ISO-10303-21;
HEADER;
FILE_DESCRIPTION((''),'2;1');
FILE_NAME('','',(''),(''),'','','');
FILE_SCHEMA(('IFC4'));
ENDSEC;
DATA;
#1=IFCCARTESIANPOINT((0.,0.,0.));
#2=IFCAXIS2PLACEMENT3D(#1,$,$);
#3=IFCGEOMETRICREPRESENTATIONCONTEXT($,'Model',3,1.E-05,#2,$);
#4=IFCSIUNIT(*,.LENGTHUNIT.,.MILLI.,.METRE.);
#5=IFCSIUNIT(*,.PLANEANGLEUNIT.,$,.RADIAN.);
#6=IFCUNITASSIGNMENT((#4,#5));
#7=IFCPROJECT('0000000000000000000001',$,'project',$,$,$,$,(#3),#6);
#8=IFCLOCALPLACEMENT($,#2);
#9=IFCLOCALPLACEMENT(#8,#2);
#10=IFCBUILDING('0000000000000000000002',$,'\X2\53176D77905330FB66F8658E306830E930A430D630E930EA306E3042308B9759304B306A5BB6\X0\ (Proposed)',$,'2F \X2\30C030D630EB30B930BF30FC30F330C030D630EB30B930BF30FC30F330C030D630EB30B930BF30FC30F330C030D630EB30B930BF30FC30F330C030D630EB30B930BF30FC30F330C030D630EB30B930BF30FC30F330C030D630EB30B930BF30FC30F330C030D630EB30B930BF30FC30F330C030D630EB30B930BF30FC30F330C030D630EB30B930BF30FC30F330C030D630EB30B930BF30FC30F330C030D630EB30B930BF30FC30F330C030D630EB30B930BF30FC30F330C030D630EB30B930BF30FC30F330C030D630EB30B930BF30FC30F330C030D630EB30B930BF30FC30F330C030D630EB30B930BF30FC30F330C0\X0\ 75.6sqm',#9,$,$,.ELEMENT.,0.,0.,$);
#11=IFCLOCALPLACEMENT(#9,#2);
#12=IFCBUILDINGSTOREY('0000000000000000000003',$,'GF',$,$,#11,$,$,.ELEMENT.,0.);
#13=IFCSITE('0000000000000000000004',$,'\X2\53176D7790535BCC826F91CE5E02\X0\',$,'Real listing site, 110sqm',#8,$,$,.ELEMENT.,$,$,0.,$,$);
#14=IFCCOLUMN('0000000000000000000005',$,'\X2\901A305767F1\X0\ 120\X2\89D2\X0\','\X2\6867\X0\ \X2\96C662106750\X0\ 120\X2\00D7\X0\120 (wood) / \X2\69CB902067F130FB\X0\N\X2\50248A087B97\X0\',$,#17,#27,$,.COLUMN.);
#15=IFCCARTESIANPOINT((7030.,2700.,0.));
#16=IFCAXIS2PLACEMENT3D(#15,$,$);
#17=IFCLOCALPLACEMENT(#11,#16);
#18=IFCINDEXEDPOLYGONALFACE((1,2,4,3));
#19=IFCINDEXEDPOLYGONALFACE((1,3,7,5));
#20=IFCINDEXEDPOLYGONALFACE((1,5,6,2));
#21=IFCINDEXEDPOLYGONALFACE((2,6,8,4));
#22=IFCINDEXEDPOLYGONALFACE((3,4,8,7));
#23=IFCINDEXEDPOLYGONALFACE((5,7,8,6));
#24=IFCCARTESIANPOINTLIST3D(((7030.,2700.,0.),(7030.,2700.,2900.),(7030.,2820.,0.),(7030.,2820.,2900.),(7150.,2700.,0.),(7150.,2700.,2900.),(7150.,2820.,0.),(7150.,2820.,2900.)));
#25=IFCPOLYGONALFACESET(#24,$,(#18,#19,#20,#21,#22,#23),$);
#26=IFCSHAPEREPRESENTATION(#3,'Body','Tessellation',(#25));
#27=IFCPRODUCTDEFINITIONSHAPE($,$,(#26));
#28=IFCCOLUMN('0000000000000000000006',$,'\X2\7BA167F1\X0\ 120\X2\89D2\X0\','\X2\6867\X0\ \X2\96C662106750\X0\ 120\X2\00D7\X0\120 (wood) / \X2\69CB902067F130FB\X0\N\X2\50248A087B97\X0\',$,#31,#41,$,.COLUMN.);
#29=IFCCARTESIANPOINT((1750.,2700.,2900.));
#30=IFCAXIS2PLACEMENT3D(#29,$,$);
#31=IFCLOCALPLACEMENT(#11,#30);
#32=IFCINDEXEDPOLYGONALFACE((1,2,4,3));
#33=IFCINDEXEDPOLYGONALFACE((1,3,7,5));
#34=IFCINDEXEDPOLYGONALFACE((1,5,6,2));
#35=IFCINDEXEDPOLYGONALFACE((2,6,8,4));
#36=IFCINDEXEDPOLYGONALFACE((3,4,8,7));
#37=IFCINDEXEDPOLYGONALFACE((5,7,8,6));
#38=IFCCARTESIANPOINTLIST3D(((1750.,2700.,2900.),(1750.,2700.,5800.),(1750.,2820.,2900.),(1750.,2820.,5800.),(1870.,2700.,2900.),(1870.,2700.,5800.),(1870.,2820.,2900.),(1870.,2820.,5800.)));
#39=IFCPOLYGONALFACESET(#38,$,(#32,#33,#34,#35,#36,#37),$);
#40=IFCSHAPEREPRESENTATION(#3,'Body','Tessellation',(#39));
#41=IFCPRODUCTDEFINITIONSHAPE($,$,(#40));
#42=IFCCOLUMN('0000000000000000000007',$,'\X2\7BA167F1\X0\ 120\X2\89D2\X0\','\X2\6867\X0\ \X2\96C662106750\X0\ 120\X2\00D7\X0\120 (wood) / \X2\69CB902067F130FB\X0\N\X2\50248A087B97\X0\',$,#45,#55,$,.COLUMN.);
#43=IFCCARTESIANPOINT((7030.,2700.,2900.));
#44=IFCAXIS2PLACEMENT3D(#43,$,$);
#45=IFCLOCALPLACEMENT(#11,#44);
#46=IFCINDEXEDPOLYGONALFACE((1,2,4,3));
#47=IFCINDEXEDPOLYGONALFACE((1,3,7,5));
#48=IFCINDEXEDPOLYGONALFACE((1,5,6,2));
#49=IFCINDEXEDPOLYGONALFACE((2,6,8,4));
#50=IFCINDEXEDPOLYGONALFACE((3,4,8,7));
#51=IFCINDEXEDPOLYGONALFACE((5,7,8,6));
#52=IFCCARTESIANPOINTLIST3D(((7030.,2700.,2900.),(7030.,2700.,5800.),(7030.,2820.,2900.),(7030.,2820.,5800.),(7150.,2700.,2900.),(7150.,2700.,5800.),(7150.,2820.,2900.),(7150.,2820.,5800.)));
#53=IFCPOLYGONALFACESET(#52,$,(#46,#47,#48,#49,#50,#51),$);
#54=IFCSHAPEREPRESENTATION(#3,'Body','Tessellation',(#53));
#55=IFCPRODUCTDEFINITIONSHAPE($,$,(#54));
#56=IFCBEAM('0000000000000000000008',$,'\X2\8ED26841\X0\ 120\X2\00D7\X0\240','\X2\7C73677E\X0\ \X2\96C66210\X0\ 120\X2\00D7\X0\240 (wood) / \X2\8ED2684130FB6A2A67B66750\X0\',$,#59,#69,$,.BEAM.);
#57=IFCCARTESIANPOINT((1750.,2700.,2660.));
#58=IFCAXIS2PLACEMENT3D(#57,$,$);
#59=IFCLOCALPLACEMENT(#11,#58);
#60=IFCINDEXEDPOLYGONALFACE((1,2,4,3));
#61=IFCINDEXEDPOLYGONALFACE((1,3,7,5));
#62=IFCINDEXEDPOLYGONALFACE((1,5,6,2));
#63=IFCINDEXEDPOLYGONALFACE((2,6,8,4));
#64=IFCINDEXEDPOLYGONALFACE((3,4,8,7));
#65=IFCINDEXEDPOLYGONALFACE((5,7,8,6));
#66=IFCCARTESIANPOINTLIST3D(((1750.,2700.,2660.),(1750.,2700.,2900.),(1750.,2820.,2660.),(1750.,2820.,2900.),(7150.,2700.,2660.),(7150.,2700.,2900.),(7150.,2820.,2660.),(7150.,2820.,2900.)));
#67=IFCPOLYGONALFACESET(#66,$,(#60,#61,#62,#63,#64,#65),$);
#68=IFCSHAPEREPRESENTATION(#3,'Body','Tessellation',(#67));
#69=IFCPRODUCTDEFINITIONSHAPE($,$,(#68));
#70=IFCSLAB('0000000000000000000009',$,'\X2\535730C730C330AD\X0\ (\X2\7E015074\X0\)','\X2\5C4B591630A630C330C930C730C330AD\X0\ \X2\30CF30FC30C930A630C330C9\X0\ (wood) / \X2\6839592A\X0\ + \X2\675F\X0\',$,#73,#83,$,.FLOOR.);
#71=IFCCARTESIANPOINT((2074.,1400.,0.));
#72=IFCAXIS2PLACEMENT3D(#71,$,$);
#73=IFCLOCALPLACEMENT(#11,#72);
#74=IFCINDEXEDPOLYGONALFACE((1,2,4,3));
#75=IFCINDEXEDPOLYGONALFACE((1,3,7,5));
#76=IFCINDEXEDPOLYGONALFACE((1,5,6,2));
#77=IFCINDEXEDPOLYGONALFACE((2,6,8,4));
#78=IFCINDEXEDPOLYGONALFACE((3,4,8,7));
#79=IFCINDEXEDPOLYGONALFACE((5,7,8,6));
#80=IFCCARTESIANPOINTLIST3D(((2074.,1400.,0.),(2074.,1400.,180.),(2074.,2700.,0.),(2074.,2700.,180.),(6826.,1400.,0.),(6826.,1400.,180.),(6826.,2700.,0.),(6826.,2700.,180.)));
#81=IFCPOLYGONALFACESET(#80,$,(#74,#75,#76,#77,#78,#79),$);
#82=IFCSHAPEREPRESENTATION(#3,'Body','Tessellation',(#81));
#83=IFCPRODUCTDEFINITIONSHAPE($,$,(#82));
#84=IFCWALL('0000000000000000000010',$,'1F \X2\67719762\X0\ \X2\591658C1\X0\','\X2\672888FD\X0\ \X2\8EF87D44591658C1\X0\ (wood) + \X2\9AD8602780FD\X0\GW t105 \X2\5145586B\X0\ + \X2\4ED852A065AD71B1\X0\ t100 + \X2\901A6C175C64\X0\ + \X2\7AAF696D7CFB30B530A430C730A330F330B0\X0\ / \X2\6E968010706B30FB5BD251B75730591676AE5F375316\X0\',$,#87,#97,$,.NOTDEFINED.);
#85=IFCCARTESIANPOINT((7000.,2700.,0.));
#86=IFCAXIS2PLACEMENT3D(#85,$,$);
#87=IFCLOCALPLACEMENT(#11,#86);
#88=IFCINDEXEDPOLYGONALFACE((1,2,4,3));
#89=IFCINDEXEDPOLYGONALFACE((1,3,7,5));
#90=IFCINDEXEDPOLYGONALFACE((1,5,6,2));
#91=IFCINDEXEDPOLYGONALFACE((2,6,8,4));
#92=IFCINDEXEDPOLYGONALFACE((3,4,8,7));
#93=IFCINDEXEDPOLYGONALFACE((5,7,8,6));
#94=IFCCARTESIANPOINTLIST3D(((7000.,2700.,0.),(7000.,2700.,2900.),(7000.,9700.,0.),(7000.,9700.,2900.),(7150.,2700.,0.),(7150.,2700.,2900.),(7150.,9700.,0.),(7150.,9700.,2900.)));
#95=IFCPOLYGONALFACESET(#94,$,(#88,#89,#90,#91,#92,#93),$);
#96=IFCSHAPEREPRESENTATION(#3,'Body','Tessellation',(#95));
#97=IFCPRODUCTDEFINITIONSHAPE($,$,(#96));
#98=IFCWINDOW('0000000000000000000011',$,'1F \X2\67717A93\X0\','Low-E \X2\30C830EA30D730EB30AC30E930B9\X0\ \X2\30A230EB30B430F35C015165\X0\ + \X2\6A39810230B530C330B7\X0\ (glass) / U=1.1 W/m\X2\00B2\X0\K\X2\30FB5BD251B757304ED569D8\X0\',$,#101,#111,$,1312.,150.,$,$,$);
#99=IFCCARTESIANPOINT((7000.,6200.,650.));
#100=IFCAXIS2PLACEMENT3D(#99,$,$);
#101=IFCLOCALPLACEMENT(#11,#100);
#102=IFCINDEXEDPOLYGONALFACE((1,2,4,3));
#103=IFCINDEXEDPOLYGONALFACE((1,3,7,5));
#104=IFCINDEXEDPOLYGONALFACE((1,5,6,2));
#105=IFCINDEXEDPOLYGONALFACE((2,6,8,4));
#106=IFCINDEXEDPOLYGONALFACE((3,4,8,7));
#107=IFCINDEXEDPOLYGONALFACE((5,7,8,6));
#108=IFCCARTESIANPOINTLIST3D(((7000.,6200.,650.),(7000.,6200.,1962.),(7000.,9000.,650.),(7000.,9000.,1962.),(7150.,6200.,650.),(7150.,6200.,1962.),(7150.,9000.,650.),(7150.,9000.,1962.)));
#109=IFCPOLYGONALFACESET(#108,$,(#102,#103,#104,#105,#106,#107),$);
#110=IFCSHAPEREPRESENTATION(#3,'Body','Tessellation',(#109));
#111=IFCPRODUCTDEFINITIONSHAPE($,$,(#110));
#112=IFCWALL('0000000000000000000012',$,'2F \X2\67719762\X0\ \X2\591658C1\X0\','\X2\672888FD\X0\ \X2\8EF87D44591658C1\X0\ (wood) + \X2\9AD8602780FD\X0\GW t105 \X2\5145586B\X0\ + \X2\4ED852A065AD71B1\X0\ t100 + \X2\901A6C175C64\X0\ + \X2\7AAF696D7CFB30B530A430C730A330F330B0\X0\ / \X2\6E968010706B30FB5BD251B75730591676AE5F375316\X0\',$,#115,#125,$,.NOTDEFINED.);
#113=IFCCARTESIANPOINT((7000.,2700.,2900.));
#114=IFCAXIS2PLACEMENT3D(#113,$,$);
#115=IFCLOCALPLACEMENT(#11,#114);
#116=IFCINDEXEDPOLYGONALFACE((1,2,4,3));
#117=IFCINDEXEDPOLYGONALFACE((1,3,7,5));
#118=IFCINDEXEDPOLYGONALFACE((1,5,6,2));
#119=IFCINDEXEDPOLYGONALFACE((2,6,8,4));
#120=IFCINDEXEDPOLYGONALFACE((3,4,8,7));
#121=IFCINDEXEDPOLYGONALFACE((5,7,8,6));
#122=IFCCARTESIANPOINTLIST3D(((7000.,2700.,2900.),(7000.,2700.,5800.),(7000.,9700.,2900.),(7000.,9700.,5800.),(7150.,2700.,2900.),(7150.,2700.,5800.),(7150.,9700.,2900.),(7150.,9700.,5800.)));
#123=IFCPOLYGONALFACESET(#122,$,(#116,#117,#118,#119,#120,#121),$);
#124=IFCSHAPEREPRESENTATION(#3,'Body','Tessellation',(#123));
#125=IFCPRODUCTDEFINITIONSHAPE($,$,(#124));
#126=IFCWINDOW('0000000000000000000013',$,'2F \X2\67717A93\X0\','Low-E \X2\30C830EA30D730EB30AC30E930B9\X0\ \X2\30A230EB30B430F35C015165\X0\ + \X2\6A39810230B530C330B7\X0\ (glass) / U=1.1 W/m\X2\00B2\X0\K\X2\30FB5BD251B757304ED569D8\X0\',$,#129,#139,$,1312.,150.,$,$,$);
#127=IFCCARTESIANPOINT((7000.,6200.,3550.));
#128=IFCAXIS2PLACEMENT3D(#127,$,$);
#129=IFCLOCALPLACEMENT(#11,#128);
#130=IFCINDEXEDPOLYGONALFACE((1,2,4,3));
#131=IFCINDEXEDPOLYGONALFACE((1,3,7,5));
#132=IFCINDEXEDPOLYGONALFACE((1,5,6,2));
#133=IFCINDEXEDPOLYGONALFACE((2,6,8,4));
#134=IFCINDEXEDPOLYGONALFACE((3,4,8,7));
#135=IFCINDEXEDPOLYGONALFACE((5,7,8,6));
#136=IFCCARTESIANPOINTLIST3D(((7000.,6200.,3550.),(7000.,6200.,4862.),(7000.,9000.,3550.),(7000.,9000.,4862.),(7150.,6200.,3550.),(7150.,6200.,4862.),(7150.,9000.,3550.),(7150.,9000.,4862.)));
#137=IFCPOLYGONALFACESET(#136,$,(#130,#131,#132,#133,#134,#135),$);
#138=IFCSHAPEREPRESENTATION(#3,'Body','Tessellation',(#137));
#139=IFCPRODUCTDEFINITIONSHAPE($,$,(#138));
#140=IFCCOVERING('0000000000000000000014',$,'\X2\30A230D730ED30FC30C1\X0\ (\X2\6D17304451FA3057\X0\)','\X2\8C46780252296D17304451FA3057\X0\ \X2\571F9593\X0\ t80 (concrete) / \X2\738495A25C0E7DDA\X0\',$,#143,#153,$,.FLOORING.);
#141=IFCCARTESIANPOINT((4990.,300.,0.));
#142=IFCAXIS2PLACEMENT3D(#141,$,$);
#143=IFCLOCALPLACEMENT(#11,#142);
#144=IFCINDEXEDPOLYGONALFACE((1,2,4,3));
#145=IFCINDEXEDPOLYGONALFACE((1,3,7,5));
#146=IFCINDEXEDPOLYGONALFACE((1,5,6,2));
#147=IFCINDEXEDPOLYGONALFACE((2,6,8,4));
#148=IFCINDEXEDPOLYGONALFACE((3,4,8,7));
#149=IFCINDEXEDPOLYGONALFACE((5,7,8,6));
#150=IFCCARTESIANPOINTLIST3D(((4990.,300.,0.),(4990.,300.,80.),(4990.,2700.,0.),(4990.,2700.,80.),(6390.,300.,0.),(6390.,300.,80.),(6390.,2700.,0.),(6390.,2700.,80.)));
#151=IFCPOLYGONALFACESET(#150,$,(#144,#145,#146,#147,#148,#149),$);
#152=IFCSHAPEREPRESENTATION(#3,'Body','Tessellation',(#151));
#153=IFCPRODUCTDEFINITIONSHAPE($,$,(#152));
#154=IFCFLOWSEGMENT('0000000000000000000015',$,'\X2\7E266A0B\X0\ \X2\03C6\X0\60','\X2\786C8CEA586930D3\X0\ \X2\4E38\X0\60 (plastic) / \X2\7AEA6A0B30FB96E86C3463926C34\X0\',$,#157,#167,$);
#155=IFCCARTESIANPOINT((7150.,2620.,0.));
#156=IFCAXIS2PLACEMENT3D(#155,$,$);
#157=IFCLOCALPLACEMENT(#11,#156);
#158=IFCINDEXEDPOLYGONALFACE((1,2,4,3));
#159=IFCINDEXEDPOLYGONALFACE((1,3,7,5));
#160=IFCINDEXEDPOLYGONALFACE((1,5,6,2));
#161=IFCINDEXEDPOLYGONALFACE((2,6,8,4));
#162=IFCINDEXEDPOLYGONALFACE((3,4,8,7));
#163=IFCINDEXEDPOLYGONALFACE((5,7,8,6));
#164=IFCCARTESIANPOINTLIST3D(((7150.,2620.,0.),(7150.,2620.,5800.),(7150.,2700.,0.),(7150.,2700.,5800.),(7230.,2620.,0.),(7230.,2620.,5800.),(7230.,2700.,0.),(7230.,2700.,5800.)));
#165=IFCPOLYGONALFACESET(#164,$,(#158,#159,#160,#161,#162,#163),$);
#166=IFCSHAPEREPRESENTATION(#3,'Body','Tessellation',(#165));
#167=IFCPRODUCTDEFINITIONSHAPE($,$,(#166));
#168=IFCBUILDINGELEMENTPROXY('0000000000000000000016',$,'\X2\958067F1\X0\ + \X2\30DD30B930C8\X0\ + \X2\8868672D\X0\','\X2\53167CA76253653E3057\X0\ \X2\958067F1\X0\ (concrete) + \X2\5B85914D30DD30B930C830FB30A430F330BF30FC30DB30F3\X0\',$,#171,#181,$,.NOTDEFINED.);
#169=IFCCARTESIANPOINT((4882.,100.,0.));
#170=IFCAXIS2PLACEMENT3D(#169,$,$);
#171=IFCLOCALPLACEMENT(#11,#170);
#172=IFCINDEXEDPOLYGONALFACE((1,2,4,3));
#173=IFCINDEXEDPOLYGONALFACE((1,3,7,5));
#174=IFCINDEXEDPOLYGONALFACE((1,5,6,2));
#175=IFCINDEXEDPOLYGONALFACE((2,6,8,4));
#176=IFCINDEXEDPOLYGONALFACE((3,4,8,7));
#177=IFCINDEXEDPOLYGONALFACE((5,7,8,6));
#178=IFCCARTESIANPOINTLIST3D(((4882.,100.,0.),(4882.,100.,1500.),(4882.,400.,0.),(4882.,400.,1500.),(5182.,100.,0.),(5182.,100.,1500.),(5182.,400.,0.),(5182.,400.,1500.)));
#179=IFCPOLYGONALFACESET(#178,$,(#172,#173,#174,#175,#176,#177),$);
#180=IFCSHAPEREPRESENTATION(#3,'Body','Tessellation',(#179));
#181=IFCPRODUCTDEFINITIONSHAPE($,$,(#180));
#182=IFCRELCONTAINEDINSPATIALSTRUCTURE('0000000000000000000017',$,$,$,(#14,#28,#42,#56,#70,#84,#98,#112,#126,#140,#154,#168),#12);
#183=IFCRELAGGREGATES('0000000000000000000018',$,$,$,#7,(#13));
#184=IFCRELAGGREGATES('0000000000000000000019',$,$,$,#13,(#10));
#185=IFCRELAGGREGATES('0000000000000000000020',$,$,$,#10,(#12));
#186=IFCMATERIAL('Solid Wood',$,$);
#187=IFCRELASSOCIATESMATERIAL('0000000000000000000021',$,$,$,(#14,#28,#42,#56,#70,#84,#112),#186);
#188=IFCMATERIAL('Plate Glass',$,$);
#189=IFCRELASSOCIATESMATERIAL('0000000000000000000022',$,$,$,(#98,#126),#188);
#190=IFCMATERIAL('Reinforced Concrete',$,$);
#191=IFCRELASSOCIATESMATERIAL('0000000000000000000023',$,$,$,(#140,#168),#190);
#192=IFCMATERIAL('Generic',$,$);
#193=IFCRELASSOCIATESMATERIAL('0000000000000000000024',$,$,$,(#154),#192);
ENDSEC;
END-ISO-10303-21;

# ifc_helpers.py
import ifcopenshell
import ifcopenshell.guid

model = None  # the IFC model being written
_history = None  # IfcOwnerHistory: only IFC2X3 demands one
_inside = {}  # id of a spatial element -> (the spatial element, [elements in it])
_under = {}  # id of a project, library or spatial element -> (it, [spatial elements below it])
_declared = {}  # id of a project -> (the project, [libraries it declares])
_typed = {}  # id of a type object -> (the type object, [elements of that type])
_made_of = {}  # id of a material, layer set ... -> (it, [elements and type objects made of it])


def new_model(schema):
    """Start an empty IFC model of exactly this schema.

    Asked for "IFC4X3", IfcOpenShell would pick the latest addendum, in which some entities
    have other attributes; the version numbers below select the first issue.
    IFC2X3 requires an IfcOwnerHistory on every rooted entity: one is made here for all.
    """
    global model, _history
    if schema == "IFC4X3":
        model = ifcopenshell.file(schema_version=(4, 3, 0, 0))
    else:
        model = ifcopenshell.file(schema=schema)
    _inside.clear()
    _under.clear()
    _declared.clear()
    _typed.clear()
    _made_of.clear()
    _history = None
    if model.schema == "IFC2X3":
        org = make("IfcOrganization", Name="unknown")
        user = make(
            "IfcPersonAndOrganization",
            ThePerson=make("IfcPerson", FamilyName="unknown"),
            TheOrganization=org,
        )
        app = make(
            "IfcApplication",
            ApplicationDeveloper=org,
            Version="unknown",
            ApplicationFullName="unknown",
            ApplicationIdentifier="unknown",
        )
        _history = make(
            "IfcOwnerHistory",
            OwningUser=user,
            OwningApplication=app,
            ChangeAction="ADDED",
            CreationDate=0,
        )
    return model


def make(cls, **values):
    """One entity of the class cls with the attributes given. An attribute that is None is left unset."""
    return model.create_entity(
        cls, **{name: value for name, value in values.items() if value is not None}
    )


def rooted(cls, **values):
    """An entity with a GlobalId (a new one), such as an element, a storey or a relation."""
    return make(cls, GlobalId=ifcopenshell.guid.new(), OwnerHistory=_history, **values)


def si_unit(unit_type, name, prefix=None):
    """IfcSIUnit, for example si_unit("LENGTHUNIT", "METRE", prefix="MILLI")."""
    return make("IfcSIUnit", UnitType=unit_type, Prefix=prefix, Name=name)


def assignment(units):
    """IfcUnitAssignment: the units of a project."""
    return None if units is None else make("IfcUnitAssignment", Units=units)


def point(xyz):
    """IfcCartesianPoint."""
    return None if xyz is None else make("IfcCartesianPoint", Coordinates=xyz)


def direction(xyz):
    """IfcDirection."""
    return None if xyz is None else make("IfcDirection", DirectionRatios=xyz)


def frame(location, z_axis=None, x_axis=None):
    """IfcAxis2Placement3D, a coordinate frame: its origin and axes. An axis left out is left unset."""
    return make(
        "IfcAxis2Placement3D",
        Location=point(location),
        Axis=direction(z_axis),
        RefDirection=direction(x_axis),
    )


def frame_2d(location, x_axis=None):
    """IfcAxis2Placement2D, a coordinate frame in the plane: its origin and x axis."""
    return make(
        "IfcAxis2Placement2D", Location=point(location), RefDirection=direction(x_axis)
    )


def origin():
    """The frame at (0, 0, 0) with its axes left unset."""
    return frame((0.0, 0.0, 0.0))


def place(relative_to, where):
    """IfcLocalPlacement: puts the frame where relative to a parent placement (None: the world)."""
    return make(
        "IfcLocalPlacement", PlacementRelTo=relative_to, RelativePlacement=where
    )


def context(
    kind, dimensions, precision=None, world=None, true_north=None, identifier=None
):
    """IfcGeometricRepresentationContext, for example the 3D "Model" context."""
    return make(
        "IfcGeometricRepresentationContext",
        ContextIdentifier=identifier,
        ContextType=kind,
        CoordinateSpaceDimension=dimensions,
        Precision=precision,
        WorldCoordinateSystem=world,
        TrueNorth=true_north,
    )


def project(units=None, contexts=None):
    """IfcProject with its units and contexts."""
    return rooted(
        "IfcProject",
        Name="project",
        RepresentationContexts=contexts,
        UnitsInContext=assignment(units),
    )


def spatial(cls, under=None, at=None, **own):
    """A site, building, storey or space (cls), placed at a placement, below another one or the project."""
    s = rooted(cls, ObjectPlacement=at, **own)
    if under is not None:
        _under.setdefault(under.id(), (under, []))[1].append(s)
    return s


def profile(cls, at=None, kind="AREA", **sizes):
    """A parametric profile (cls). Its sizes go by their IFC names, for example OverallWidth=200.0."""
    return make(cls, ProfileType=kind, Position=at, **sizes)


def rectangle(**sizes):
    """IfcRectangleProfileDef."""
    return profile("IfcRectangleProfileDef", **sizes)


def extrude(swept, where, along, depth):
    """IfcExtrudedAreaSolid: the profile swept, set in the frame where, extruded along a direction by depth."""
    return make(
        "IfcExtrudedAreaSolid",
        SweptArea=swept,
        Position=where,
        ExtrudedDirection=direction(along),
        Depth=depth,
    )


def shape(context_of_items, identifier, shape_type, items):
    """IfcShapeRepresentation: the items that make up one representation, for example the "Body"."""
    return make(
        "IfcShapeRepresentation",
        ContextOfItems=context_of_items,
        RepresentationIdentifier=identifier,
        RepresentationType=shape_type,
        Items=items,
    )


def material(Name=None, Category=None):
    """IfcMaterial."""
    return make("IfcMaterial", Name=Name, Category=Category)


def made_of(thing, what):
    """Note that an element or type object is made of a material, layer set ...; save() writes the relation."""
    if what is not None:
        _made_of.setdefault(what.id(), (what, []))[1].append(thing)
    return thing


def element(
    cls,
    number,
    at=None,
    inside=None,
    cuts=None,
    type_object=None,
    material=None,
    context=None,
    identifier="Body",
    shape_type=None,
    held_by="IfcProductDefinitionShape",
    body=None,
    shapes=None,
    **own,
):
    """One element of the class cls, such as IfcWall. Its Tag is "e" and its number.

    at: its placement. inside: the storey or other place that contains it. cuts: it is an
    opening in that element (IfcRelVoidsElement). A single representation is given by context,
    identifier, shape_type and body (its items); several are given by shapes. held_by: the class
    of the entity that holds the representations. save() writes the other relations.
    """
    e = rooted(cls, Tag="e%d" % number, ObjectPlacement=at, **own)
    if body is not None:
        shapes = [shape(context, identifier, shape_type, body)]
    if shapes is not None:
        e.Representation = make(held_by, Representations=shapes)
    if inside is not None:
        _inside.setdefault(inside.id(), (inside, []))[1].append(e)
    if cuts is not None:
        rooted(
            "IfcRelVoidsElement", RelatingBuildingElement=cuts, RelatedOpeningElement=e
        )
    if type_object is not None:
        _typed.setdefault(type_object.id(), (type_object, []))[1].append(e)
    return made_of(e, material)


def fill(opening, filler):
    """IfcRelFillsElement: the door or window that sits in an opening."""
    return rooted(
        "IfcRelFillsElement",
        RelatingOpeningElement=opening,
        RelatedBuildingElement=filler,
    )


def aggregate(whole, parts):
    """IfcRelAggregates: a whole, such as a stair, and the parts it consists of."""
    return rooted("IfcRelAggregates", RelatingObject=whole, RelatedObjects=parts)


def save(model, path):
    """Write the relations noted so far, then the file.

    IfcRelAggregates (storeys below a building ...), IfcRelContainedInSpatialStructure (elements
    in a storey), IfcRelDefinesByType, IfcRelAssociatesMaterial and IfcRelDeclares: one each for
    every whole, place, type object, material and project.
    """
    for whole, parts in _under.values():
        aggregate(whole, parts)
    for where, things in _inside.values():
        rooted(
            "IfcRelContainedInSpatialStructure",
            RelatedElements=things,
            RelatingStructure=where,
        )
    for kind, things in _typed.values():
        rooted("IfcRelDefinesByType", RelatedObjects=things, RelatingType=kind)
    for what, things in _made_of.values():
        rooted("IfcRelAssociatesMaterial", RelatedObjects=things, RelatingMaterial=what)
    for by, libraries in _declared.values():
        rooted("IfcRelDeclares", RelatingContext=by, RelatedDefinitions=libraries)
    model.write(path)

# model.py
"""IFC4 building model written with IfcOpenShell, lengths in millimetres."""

from ifc_helpers import new_model, si_unit, frame, frame_2d, origin, place, context, project, spatial, rectangle, extrude, material, element, fill, save


model = new_model("IFC4")

# Units and contexts
model_context = context("Model", 3, precision=1e-05, world=origin())
ifc_project = project(units=[si_unit("LENGTHUNIT", "METRE", prefix="MILLI"), si_unit("PLANEANGLEUNIT", "RADIAN")], contexts=[model_context])

# Site, building, storey
site_placement = place(None, origin())
site = spatial("IfcSite", under=ifc_project, at=site_placement, Name="北海道富良野市", ObjectType="Real listing site, 110sqm", CompositionType="ELEMENT", RefElevation=0.0)
building_placement = place(site_placement, origin())
building = spatial("IfcBuilding", under=site, at=building_placement, Name="北海道・書斎とライブラリのある静かな家 (Proposed)", ObjectType="2F ダブルスターンダブルスターンダブルスターンダブルスターンダブルスターンダブルスターンダブルスターンダブルスターンダブルスターンダブルスターンダブルスターンダブルスターンダブルスターンダブルスターンダブルスターンダブルスターンダブルスターンダ 75.6sqm", CompositionType="ELEMENT", ElevationOfRefHeight=0.0, ElevationOfTerrain=0.0)
storey_placement = place(building_placement, origin())
storey = spatial("IfcBuildingStorey", under=building, at=storey_placement, Name="GF", CompositionType="ELEMENT", Elevation=0.0)

# Columns
ifc_material_1 = material(Name="Solid Wood")
column_1_placement = place(storey_placement, frame((7030.0, 2700.0, 0.0)))
element("IfcColumn", 1, at=column_1_placement, inside=storey, material=ifc_material_1, Name="通し柱 120角", Description="桧 集成材 120×120 (wood) / 構造柱・N値計算", PredefinedType="COLUMN", context=model_context, shape_type="SweptSolid", body=[
    extrude(rectangle(XDim=120.0, YDim=120.0, at=frame_2d((60.0, 60.0))), frame((7030.0, 2700.0, 0.0)), (0.0, 0.0, 1.0), 2900.0),
])
column_2_placement = place(storey_placement, frame((1750.0, 2700.0, 2900.0)))
element("IfcColumn", 2, at=column_2_placement, inside=storey, material=ifc_material_1, Name="管柱 120角", Description="桧 集成材 120×120 (wood) / 構造柱・N値計算", PredefinedType="COLUMN", context=model_context, shape_type="SweptSolid", body=[
    extrude(rectangle(XDim=120.0, YDim=120.0, at=frame_2d((60.0, 60.0))), frame((1750.0, 2700.0, 2900.0)), (0.0, 0.0, 1.0), 2900.0),
])
column_3_placement = place(storey_placement, frame((7030.0, 2700.0, 2900.0)))
element("IfcColumn", 3, at=column_3_placement, inside=storey, material=ifc_material_1, Name="管柱 120角", Description="桧 集成材 120×120 (wood) / 構造柱・N値計算", PredefinedType="COLUMN", context=model_context, shape_type="SweptSolid", body=[
    extrude(rectangle(XDim=120.0, YDim=120.0, at=frame_2d((60.0, 60.0))), frame((7030.0, 2700.0, 2900.0)), (0.0, 0.0, 1.0), 2900.0),
])

# Beam
beam_1_placement = place(storey_placement, frame((1750.0, 2700.0, 2660.0)))
element("IfcBeam", 4, at=beam_1_placement, inside=storey, material=ifc_material_1, Name="軒桁 120×240", Description="米松 集成 120×240 (wood) / 軒桁・横架材", PredefinedType="BEAM", context=model_context, shape_type="SweptSolid", body=[
    extrude(rectangle(XDim=5400.0, YDim=120.0, at=frame_2d((2700.0, 60.0))), frame((1750.0, 2700.0, 2660.0)), (0.0, 0.0, 1.0), 240.0),
])

# Slab
slab_placement = place(storey_placement, frame((2074.0, 1400.0, 0.0)))
element("IfcSlab", 5, at=slab_placement, inside=storey, material=ifc_material_1, Name="南デッキ (縁側)", Description="屋外ウッドデッキ ハードウッド (wood) / 根太 + 束", PredefinedType="FLOOR", context=model_context, shape_type="SweptSolid", body=[
    extrude(rectangle(XDim=4752.0, YDim=1300.0, at=frame_2d((2376.0, 650.0))), frame((2074.0, 1400.0, 0.0)), (0.0, 0.0, 1.0), 180.0),
])

# Walls, openings, windows
wall_1_placement = place(storey_placement, frame((7000.0, 2700.0, 0.0)))
wall_1 = element("IfcWall", 6, at=wall_1_placement, inside=storey, material=ifc_material_1, Name="1F 東面 外壁", Description="木製 軸組外壁 (wood) + 高性能GW t105 充填 + 付加断熱 t100 + 通気層 + 窯業系サイディング / 準耐火・寒冷地外皮強化", PredefinedType="NOTDEFINED", context=model_context, shape_type="SweptSolid", body=[
    extrude(rectangle(XDim=150.0, YDim=7000.0, at=frame_2d((75.0, 3500.0))), frame((7000.0, 2700.0, 0.0)), (0.0, 0.0, 1.0), 2900.0),
])
opening_1_placement = place(storey_placement, frame((7000.0, 6200.0, 650.0)))
opening_1 = element("IfcOpeningElement", 7, at=opening_1_placement, cuts=wall_1, PredefinedType="NOTDEFINED", context=model_context, shape_type="SweptSolid", body=[
    extrude(rectangle(XDim=150.0, YDim=2800.0, at=frame_2d((75.0, 1400.0))), frame((7000.0, 6200.0, 650.0)), (0.0, 0.0, 1.0), 1312.0),
])
ifc_material_2 = material(Name="Plate Glass")
window_1_placement = place(storey_placement, frame((7000.0, 6200.0, 650.0)))
window_1 = element("IfcWindow", 8, at=window_1_placement, inside=storey, material=ifc_material_2, Name="1F 東窓", Description="Low-E トリプルガラス アルゴン封入 + 樹脂サッシ (glass) / U=1.1 W/m²K・寒冷地仕様", OverallHeight=1312.0, OverallWidth=150.0, context=model_context, shape_type="SweptSolid", body=[
    extrude(rectangle(XDim=150.0, YDim=2800.0, at=frame_2d((75.0, 1400.0))), frame((7000.0, 6200.0, 650.0)), (0.0, 0.0, 1.0), 1312.0),
])
fill(opening_1, window_1)
wall_2_placement = place(storey_placement, frame((7000.0, 2700.0, 2900.0)))
wall_2 = element("IfcWall", 9, at=wall_2_placement, inside=storey, material=ifc_material_1, Name="2F 東面 外壁", Description="木製 軸組外壁 (wood) + 高性能GW t105 充填 + 付加断熱 t100 + 通気層 + 窯業系サイディング / 準耐火・寒冷地外皮強化", PredefinedType="NOTDEFINED", context=model_context, shape_type="SweptSolid", body=[
    extrude(rectangle(XDim=150.0, YDim=7000.0, at=frame_2d((75.0, 3500.0))), frame((7000.0, 2700.0, 2900.0)), (0.0, 0.0, 1.0), 2900.0),
])
opening_2_placement = place(storey_placement, frame((7000.0, 6200.0, 3550.0)))
opening_2 = element("IfcOpeningElement", 10, at=opening_2_placement, cuts=wall_2, PredefinedType="NOTDEFINED", context=model_context, shape_type="SweptSolid", body=[
    extrude(rectangle(XDim=150.0, YDim=2800.0, at=frame_2d((75.0, 1400.0))), frame((7000.0, 6200.0, 3550.0)), (0.0, 0.0, 1.0), 1312.0),
])
window_2_placement = place(storey_placement, frame((7000.0, 6200.0, 3550.0)))
window_2 = element("IfcWindow", 11, at=window_2_placement, inside=storey, material=ifc_material_2, Name="2F 東窓", Description="Low-E トリプルガラス アルゴン封入 + 樹脂サッシ (glass) / U=1.1 W/m²K・寒冷地仕様", OverallHeight=1312.0, OverallWidth=150.0, context=model_context, shape_type="SweptSolid", body=[
    extrude(rectangle(XDim=150.0, YDim=2800.0, at=frame_2d((75.0, 1400.0))), frame((7000.0, 6200.0, 3550.0)), (0.0, 0.0, 1.0), 1312.0),
])
fill(opening_2, window_2)

# Covering
ifc_material_3 = material(Name="Reinforced Concrete")
covering_1_placement = place(storey_placement, frame((4990.0, 300.0, 0.0)))
element("IfcCovering", 12, at=covering_1_placement, inside=storey, material=ifc_material_3, Name="アプローチ (洗い出し)", Description="豆砂利洗い出し 土間 t80 (concrete) / 玄関導線", PredefinedType="FLOORING", context=model_context, shape_type="SweptSolid", body=[
    extrude(rectangle(XDim=1400.0, YDim=2400.0, at=frame_2d((700.0, 1200.0))), frame((4990.0, 300.0, 0.0)), (0.0, 0.0, 1.0), 80.0),
])

# Flow segment
ifc_material_4 = material(Name="Generic")
flow_segment_placement = place(storey_placement, frame((7150.0, 2620.0, 0.0)))
element("IfcFlowSegment", 13, at=flow_segment_placement, inside=storey, material=ifc_material_4, Name="縦樋 φ60", Description="硬質塩ビ 丸60 (plastic) / 竪樋・雨水排水", context=model_context, shape_type="SweptSolid", body=[
    extrude(rectangle(XDim=80.0, YDim=80.0, at=frame_2d((40.0, 40.0))), frame((7150.0, 2620.0, 0.0)), (0.0, 0.0, 1.0), 5800.0),
])

# Building element proxy
proxy_placement = place(storey_placement, frame((4882.0, 100.0, 0.0)))
element("IfcBuildingElementProxy", 14, at=proxy_placement, inside=storey, material=ifc_material_3, Name="門柱 + ポスト + 表札", Description="化粧打放し 門柱 (concrete) + 宅配ポスト・インターホン", PredefinedType="NOTDEFINED", context=model_context, shape_type="SweptSolid", body=[
    extrude(rectangle(XDim=300.0, YDim=300.0, at=frame_2d((150.0, 150.0))), frame((4882.0, 100.0, 0.0)), (0.0, 0.0, 1.0), 1500.0),
])

save(model, "model.ifc")
